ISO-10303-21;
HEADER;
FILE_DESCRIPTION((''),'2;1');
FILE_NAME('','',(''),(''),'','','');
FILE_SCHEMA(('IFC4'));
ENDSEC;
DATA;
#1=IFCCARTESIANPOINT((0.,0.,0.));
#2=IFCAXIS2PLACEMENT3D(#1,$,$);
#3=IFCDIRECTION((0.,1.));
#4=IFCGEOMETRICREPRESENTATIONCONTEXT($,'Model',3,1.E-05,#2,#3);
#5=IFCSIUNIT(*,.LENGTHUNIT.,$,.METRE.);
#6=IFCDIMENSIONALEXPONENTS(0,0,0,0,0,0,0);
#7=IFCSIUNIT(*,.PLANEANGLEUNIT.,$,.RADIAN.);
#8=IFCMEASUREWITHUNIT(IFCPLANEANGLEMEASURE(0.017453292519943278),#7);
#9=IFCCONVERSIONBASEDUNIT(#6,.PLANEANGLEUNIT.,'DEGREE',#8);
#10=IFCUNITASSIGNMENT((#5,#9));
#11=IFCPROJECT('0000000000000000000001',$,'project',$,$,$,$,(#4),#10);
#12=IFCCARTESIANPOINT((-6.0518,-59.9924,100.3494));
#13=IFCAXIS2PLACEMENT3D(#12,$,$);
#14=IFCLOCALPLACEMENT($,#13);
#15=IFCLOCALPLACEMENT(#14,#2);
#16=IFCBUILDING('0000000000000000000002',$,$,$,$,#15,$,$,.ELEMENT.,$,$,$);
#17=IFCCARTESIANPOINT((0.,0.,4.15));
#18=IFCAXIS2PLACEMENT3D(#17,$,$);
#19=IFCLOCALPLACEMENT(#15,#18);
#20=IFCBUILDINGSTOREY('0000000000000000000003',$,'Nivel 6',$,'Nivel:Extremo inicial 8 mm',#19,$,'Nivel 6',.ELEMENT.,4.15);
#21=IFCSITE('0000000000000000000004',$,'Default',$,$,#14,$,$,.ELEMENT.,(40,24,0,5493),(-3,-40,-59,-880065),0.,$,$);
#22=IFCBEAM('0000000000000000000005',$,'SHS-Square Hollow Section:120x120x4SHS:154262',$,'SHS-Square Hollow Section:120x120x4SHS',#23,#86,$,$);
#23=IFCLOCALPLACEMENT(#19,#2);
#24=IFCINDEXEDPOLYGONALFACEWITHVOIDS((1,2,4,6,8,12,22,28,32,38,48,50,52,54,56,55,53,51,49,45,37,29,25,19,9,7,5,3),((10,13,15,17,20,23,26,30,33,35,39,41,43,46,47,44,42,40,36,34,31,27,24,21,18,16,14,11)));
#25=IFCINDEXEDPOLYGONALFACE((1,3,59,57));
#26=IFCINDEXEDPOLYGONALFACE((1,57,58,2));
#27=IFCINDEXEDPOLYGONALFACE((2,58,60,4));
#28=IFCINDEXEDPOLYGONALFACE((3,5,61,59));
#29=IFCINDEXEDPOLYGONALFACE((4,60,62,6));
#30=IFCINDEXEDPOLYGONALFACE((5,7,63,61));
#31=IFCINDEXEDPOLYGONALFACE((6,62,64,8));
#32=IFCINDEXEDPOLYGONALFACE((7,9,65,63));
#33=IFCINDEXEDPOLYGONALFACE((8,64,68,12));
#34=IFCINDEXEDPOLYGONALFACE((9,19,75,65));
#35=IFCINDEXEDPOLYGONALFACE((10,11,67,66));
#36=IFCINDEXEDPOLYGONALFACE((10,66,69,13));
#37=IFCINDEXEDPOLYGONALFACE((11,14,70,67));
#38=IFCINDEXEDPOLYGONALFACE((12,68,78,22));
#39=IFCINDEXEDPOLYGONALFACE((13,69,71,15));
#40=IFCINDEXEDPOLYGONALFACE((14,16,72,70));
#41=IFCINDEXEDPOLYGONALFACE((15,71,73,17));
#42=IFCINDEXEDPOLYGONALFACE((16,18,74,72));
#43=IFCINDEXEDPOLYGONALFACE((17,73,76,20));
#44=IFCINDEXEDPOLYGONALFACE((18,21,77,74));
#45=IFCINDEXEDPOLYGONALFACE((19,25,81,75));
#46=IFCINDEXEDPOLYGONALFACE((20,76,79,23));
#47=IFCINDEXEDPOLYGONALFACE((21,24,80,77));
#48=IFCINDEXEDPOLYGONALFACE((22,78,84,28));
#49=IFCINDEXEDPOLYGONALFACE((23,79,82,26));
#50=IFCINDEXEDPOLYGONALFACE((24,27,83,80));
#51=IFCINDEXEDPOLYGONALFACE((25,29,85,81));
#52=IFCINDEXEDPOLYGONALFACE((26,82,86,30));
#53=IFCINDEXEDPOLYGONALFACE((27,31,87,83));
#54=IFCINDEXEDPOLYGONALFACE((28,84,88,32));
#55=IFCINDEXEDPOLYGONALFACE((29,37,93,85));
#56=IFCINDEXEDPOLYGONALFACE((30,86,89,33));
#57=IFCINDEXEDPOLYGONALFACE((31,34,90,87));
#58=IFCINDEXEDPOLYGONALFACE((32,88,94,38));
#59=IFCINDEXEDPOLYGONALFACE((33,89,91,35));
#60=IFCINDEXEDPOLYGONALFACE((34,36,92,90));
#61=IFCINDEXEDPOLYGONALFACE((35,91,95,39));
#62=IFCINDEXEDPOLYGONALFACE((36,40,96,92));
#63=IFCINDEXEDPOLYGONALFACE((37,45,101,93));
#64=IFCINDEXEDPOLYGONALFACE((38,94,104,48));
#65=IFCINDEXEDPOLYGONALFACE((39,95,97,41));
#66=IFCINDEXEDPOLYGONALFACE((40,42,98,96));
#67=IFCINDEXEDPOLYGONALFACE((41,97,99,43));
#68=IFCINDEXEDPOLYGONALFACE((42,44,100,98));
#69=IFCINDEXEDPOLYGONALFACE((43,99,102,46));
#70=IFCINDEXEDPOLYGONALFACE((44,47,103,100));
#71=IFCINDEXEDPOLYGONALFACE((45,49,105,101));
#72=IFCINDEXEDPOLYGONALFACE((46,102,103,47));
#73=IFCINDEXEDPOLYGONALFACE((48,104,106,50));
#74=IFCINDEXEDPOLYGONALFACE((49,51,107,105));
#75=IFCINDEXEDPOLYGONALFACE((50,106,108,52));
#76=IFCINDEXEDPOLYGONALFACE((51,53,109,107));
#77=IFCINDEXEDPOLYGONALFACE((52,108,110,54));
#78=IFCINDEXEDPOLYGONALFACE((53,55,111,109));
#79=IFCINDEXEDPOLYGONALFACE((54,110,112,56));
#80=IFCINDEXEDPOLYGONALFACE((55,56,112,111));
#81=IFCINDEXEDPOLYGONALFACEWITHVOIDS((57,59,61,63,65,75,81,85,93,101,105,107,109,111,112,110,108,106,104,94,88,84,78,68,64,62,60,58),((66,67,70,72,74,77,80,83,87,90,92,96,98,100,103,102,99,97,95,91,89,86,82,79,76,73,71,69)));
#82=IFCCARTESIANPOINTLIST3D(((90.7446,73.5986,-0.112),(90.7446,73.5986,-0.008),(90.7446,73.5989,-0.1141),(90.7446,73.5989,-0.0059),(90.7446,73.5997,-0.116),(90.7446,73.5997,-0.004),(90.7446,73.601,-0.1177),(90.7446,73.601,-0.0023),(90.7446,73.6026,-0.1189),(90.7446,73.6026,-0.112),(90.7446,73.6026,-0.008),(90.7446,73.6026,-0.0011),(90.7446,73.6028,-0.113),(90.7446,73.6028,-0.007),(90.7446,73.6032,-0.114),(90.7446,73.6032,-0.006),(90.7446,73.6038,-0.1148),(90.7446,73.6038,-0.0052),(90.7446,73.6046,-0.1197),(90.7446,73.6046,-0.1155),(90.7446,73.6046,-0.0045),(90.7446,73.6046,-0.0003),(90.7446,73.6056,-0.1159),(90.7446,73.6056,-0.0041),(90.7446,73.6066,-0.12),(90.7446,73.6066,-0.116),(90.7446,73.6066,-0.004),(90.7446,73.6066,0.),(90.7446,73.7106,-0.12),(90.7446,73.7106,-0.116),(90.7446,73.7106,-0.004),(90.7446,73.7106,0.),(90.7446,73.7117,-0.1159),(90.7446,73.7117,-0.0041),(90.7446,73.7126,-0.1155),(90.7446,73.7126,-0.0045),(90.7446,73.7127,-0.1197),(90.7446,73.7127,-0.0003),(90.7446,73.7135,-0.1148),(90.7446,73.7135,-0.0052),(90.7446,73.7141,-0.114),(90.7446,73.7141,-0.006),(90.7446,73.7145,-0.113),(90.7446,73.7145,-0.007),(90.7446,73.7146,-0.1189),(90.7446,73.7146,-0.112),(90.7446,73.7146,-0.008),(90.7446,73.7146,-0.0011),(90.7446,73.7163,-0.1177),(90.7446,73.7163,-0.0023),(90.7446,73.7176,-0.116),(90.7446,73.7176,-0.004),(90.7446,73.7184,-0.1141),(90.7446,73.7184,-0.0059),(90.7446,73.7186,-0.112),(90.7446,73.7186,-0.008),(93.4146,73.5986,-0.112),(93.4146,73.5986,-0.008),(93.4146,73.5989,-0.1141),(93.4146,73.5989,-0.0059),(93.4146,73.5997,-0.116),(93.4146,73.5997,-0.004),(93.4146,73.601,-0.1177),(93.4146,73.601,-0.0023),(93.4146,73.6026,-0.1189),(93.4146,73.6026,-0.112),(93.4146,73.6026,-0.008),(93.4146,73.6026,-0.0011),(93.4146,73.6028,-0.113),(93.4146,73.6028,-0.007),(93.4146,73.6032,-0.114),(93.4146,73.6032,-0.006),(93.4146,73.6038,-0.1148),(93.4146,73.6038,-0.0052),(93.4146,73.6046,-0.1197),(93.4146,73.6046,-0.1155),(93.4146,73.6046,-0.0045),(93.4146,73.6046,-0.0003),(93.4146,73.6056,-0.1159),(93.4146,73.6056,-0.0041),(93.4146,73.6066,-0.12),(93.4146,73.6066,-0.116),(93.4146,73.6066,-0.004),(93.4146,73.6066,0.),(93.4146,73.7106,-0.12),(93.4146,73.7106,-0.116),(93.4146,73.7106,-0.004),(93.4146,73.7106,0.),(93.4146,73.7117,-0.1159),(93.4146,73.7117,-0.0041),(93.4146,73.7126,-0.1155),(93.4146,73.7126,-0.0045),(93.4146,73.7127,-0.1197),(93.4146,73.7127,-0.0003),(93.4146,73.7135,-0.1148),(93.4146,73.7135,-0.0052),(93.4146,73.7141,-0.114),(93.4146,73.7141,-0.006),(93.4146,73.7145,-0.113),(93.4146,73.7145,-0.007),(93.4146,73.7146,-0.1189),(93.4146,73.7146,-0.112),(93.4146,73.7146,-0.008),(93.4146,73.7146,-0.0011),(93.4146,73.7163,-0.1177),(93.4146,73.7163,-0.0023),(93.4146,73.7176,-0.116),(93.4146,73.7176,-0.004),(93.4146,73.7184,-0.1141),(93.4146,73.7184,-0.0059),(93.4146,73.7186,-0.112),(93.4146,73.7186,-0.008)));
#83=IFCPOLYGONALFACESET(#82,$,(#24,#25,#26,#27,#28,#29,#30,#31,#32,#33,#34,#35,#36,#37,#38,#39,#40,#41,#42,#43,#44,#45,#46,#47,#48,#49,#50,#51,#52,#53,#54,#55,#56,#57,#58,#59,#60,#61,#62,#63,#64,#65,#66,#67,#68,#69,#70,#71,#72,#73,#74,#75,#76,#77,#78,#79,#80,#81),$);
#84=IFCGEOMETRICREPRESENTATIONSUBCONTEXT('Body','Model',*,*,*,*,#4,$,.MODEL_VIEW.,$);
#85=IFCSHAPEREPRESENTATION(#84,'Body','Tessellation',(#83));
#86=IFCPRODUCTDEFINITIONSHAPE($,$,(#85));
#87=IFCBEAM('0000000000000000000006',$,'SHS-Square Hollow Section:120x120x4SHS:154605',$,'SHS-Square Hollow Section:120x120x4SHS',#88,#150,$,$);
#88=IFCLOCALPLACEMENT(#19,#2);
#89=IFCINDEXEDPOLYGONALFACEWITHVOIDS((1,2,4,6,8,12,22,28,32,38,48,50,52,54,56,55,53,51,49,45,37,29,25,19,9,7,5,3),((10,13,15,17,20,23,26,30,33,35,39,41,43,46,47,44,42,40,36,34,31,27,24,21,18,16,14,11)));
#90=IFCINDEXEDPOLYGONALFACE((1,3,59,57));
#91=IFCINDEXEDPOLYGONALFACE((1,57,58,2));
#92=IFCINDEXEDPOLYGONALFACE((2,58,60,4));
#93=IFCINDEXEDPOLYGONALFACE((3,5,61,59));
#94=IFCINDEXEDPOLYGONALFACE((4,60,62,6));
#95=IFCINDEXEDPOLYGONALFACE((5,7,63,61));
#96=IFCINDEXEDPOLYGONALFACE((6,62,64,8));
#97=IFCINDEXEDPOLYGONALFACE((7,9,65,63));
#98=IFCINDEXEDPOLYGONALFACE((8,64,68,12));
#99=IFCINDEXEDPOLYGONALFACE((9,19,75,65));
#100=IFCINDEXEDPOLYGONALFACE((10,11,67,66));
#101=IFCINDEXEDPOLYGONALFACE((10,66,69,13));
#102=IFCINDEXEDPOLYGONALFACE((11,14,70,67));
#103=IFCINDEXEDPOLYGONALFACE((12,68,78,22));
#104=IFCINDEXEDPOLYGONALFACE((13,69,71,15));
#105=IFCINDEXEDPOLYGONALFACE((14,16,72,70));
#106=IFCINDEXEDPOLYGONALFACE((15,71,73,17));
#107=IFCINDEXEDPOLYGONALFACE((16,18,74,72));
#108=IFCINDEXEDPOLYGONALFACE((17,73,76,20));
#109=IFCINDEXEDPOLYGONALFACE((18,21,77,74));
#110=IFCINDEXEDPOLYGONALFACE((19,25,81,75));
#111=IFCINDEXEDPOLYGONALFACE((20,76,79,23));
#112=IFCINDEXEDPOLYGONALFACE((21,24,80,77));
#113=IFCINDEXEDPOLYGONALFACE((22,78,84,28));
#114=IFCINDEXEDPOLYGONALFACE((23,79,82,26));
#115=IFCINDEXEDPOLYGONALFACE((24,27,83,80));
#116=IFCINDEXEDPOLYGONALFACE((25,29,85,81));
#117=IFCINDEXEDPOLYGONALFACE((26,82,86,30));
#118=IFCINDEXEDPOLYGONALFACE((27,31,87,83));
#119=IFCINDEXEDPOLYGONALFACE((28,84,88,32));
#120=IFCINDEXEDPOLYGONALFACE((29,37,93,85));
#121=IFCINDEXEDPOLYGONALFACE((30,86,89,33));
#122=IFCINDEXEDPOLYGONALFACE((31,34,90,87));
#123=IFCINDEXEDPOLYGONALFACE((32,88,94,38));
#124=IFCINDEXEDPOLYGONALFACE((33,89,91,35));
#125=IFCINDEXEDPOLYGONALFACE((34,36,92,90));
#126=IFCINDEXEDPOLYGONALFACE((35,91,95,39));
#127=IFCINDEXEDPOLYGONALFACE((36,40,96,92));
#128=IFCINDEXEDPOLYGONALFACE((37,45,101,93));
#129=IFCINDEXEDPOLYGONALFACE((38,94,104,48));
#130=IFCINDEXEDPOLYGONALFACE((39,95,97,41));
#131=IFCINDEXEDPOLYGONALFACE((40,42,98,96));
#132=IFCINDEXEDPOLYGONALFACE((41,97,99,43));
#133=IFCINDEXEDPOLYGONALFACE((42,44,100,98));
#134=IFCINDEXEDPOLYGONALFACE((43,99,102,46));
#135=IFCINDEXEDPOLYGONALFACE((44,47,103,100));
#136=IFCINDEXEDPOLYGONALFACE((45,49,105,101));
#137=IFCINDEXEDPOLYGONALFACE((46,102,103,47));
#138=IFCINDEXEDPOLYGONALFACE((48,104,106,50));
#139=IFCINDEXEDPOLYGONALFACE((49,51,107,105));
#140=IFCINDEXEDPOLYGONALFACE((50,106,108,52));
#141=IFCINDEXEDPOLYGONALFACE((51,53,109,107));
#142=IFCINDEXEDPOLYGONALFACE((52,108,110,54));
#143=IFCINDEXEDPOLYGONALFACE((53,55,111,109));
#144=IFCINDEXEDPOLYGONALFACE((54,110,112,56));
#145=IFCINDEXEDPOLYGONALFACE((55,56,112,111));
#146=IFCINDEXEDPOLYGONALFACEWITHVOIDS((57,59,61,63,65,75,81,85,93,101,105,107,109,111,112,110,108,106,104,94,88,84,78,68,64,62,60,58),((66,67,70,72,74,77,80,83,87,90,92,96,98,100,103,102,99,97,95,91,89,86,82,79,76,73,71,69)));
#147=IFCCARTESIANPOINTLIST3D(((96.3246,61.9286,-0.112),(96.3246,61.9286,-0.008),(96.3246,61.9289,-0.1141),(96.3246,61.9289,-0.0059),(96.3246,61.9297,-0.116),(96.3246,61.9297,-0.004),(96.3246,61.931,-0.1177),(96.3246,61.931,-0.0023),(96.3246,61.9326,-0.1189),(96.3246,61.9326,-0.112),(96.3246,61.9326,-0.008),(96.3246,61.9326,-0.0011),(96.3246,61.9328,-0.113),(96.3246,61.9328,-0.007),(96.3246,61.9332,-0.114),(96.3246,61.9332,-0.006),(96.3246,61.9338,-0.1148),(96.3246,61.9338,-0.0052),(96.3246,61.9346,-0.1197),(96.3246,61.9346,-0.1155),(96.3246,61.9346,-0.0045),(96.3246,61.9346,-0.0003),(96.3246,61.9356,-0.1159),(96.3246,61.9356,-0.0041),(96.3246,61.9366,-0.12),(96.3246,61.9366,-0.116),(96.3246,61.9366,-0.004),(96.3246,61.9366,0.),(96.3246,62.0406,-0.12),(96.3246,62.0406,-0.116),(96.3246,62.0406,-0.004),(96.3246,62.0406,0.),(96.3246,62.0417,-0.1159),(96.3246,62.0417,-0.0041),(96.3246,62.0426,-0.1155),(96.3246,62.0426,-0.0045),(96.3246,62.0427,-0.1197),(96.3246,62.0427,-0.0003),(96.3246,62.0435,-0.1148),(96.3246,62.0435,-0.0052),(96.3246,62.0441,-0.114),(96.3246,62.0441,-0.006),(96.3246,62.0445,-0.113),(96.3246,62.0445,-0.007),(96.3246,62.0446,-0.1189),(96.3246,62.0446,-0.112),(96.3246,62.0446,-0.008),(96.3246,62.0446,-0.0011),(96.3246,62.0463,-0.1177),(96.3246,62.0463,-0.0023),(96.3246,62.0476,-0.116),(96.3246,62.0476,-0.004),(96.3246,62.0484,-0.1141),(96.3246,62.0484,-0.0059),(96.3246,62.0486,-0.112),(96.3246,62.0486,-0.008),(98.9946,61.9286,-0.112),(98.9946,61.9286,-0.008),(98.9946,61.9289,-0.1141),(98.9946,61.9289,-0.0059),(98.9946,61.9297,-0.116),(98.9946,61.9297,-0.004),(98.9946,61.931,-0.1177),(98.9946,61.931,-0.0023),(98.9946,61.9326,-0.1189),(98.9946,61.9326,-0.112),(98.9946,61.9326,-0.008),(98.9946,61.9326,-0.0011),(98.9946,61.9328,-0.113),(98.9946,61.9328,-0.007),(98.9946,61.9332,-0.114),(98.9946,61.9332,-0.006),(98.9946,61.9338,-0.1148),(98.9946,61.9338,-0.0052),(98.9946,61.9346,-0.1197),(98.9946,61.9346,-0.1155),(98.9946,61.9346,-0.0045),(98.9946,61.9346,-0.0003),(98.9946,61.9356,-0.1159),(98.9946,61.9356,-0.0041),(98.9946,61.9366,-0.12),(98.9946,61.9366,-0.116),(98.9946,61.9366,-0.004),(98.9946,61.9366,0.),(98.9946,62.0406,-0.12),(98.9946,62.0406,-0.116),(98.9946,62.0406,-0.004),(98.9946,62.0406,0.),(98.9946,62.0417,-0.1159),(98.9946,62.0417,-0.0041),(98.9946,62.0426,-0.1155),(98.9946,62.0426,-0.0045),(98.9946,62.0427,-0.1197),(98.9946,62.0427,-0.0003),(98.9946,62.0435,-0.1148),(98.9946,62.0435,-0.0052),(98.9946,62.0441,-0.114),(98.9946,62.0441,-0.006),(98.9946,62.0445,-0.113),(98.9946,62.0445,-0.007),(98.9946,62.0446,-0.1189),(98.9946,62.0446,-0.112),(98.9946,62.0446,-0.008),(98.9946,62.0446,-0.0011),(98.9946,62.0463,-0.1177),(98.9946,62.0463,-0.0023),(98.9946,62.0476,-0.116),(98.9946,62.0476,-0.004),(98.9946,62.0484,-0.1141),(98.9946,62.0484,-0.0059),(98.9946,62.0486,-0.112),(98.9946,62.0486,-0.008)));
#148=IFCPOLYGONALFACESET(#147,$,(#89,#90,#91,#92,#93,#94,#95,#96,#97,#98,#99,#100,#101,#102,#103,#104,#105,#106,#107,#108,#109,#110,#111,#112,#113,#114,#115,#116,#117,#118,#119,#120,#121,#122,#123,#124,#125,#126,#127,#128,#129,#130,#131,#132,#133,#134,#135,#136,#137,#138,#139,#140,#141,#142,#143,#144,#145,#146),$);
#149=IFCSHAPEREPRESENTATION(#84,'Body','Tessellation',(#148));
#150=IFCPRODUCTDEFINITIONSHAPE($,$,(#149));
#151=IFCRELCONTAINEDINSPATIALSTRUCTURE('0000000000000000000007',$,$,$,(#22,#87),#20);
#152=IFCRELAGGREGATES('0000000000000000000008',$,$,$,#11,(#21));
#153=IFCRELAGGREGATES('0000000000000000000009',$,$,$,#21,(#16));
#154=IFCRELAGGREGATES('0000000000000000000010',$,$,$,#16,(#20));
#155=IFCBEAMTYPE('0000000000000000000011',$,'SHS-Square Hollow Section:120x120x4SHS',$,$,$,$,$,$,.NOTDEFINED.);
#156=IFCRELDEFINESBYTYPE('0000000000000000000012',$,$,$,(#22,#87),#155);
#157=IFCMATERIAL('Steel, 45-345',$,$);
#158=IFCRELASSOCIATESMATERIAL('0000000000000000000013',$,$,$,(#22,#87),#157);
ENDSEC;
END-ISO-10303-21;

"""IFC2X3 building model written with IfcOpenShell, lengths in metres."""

from ifc_helpers import new_model, entity, si_unit, converted_unit, direction, frame, frame_2d, origin, place, context, subcontext, project, spatial, polyline, circle_curve, parameter, trimmed, segment, composite_curve, outline, extrude, material, type_object, element, save


model = new_model("IFC2X3")

# Units and contexts
model_context = context("Model", 3, precision=1e-05, world=origin(), true_north=direction((0.0, 1.0)))
body_context = subcontext(model_context, "Body", "Model", "MODEL_VIEW")
ifc_project = project(units=[si_unit("LENGTHUNIT", "METRE"), converted_unit("PLANEANGLEUNIT", "DEGREE", entity("IfcPlaneAngleMeasure", 0.017453292519943278), si_unit("PLANEANGLEUNIT", "RADIAN"), dimensions=[0, 0, 0, 0, 0, 0, 0])], contexts=[model_context])

# Site, building, storey
site_placement = place(None, frame((-6.0518, -59.9924, 100.3494)))
site = spatial("IfcSite", under=ifc_project, at=site_placement, Name="Default", CompositionType="ELEMENT", RefLatitude=(40, 24, 0, 5493), RefLongitude=(-3, -40, -59, -880065), RefElevation=0.0)
building_placement = place(site_placement, origin())
building = spatial("IfcBuilding", under=site, at=building_placement, CompositionType="ELEMENT")
storey_placement = place(building_placement, frame((0.0, 0.0, 4.15)))
storey = spatial("IfcBuildingStorey", under=building, at=storey_placement, Name="Nivel 6", ObjectType="Nivel:Extremo inicial 8 mm", LongName="Nivel 6", CompositionType="ELEMENT", Elevation=4.15)

# Beams
ifc_material_1 = material(Name="Steel, 45-345")
beam_type = type_object("IfcBeamType", Name="SHS-Square Hollow Section:120x120x4SHS", PredefinedType="NOTDEFINED")
beam_1_placement = place(storey_placement, frame((93.4746, 73.6586, 0.0), z_axis=(0.0, 0.0, 1.0), x_axis=(-1.0, 0.0, 0.0)))
element("IfcBeam", 1, at=beam_1_placement, inside=storey, type_object=beam_type, material=ifc_material_1, Name="SHS-Square Hollow Section:120x120x4SHS:154262", ObjectType="SHS-Square Hollow Section:120x120x4SHS", context=body_context, shape_type="SweptSolid", body=[
    extrude(outline(composite_curve([segment(trimmed(circle_curve(frame_2d((-0.052, -0.052), x_axis=(1.0, 0.0)), 0.008), [parameter(180.0)], [parameter(270.0)], True, "PARAMETER"), True, "CONTINUOUS"), segment(polyline([(-0.052, -0.06), (0.052, -0.06)]), True, "CONTINUOUS"), segment(trimmed(circle_curve(frame_2d((0.052, -0.052), x_axis=(1.0, 0.0)), 0.008), [parameter(270.0)], [parameter(0.0)], True, "PARAMETER"), True, "CONTINUOUS"), segment(polyline([(0.06, -0.052), (0.06, 0.052)]), True, "CONTINUOUS"), segment(trimmed(circle_curve(frame_2d((0.052, 0.052), x_axis=(1.0, 0.0)), 0.008), [parameter(360.0)], [parameter(90.0)], True, "PARAMETER"), True, "CONTINUOUS"), segment(polyline([(0.052, 0.06), (-0.052, 0.06)]), True, "CONTINUOUS"), segment(trimmed(circle_curve(frame_2d((-0.052, 0.052), x_axis=(1.0, 0.0)), 0.008), [parameter(90.0)], [parameter(180.0)], True, "PARAMETER"), True, "CONTINUOUS"), segment(polyline([(-0.06, 0.052), (-0.06, -0.052)]), True, "CONTINUOUS")], self_intersect=False), holes=[composite_curve([segment(polyline([(0.052, -0.056), (-0.052, -0.056)]), True, "CONTINUOUS"), segment(trimmed(circle_curve(frame_2d((-0.052, -0.052), x_axis=(1.0, 0.0)), 0.004), [parameter(180.0)], [parameter(270.0)], True, "PARAMETER"), False, "CONTINUOUS"), segment(polyline([(-0.056, -0.052), (-0.056, 0.052)]), True, "CONTINUOUS"), segment(trimmed(circle_curve(frame_2d((-0.052, 0.052), x_axis=(1.0, 0.0)), 0.004), [parameter(90.0)], [parameter(180.0)], True, "PARAMETER"), False, "CONTINUOUS"), segment(polyline([(-0.052, 0.056), (0.052, 0.056)]), True, "CONTINUOUS"), segment(trimmed(circle_curve(frame_2d((0.052, 0.052), x_axis=(1.0, 0.0)), 0.004), [parameter(0.0)], [parameter(90.0)], True, "PARAMETER"), False, "CONTINUOUS"), segment(polyline([(0.056, 0.052), (0.056, -0.052)]), True, "CONTINUOUS"), segment(trimmed(circle_curve(frame_2d((0.052, -0.052), x_axis=(1.0, 0.0)), 0.004), [parameter(270.0)], [parameter(0.0)], True, "PARAMETER"), False, "CONTINUOUS")], self_intersect=False)]), frame((0.06, 0.0, -0.06), z_axis=(1.0, 0.0, 0.0), x_axis=(0.0, -1.0, 0.0)), (0.0, 0.0, 1.0), 2.67),
])
beam_2_placement = place(storey_placement, frame((99.0546, 61.9886, 0.0), z_axis=(0.0, 0.0, 1.0), x_axis=(-1.0, 0.0, 0.0)))
element("IfcBeam", 2, at=beam_2_placement, inside=storey, type_object=beam_type, material=ifc_material_1, Name="SHS-Square Hollow Section:120x120x4SHS:154605", ObjectType="SHS-Square Hollow Section:120x120x4SHS", context=body_context, shape_type="SweptSolid", body=[
    extrude(outline(composite_curve([segment(trimmed(circle_curve(frame_2d((-0.052, -0.052), x_axis=(1.0, 0.0)), 0.008), [parameter(180.0)], [parameter(270.0)], True, "PARAMETER"), True, "CONTINUOUS"), segment(polyline([(-0.052, -0.06), (0.052, -0.06)]), True, "CONTINUOUS"), segment(trimmed(circle_curve(frame_2d((0.052, -0.052), x_axis=(1.0, 0.0)), 0.008), [parameter(270.0)], [parameter(0.0)], True, "PARAMETER"), True, "CONTINUOUS"), segment(polyline([(0.06, -0.052), (0.06, 0.052)]), True, "CONTINUOUS"), segment(trimmed(circle_curve(frame_2d((0.052, 0.052), x_axis=(1.0, 0.0)), 0.008), [parameter(360.0)], [parameter(90.0)], True, "PARAMETER"), True, "CONTINUOUS"), segment(polyline([(0.052, 0.06), (-0.052, 0.06)]), True, "CONTINUOUS"), segment(trimmed(circle_curve(frame_2d((-0.052, 0.052), x_axis=(1.0, 0.0)), 0.008), [parameter(90.0)], [parameter(180.0)], True, "PARAMETER"), True, "CONTINUOUS"), segment(polyline([(-0.06, 0.052), (-0.06, -0.052)]), True, "CONTINUOUS")], self_intersect=False), holes=[composite_curve([segment(polyline([(0.052, -0.056), (-0.052, -0.056)]), True, "CONTINUOUS"), segment(trimmed(circle_curve(frame_2d((-0.052, -0.052), x_axis=(1.0, 0.0)), 0.004), [parameter(180.0)], [parameter(270.0)], True, "PARAMETER"), False, "CONTINUOUS"), segment(polyline([(-0.056, -0.052), (-0.056, 0.052)]), True, "CONTINUOUS"), segment(trimmed(circle_curve(frame_2d((-0.052, 0.052), x_axis=(1.0, 0.0)), 0.004), [parameter(90.0)], [parameter(180.0)], True, "PARAMETER"), False, "CONTINUOUS"), segment(polyline([(-0.052, 0.056), (0.052, 0.056)]), True, "CONTINUOUS"), segment(trimmed(circle_curve(frame_2d((0.052, 0.052), x_axis=(1.0, 0.0)), 0.004), [parameter(0.0)], [parameter(90.0)], True, "PARAMETER"), False, "CONTINUOUS"), segment(polyline([(0.056, 0.052), (0.056, -0.052)]), True, "CONTINUOUS"), segment(trimmed(circle_curve(frame_2d((0.052, -0.052), x_axis=(1.0, 0.0)), 0.004), [parameter(270.0)], [parameter(0.0)], True, "PARAMETER"), False, "CONTINUOUS")], self_intersect=False)]), frame((0.06, 0.0, -0.06), z_axis=(1.0, 0.0, 0.0), x_axis=(0.0, -1.0, 0.0)), (0.0, 0.0, 1.0), 2.67),
])

save(model, "model.ifc")
